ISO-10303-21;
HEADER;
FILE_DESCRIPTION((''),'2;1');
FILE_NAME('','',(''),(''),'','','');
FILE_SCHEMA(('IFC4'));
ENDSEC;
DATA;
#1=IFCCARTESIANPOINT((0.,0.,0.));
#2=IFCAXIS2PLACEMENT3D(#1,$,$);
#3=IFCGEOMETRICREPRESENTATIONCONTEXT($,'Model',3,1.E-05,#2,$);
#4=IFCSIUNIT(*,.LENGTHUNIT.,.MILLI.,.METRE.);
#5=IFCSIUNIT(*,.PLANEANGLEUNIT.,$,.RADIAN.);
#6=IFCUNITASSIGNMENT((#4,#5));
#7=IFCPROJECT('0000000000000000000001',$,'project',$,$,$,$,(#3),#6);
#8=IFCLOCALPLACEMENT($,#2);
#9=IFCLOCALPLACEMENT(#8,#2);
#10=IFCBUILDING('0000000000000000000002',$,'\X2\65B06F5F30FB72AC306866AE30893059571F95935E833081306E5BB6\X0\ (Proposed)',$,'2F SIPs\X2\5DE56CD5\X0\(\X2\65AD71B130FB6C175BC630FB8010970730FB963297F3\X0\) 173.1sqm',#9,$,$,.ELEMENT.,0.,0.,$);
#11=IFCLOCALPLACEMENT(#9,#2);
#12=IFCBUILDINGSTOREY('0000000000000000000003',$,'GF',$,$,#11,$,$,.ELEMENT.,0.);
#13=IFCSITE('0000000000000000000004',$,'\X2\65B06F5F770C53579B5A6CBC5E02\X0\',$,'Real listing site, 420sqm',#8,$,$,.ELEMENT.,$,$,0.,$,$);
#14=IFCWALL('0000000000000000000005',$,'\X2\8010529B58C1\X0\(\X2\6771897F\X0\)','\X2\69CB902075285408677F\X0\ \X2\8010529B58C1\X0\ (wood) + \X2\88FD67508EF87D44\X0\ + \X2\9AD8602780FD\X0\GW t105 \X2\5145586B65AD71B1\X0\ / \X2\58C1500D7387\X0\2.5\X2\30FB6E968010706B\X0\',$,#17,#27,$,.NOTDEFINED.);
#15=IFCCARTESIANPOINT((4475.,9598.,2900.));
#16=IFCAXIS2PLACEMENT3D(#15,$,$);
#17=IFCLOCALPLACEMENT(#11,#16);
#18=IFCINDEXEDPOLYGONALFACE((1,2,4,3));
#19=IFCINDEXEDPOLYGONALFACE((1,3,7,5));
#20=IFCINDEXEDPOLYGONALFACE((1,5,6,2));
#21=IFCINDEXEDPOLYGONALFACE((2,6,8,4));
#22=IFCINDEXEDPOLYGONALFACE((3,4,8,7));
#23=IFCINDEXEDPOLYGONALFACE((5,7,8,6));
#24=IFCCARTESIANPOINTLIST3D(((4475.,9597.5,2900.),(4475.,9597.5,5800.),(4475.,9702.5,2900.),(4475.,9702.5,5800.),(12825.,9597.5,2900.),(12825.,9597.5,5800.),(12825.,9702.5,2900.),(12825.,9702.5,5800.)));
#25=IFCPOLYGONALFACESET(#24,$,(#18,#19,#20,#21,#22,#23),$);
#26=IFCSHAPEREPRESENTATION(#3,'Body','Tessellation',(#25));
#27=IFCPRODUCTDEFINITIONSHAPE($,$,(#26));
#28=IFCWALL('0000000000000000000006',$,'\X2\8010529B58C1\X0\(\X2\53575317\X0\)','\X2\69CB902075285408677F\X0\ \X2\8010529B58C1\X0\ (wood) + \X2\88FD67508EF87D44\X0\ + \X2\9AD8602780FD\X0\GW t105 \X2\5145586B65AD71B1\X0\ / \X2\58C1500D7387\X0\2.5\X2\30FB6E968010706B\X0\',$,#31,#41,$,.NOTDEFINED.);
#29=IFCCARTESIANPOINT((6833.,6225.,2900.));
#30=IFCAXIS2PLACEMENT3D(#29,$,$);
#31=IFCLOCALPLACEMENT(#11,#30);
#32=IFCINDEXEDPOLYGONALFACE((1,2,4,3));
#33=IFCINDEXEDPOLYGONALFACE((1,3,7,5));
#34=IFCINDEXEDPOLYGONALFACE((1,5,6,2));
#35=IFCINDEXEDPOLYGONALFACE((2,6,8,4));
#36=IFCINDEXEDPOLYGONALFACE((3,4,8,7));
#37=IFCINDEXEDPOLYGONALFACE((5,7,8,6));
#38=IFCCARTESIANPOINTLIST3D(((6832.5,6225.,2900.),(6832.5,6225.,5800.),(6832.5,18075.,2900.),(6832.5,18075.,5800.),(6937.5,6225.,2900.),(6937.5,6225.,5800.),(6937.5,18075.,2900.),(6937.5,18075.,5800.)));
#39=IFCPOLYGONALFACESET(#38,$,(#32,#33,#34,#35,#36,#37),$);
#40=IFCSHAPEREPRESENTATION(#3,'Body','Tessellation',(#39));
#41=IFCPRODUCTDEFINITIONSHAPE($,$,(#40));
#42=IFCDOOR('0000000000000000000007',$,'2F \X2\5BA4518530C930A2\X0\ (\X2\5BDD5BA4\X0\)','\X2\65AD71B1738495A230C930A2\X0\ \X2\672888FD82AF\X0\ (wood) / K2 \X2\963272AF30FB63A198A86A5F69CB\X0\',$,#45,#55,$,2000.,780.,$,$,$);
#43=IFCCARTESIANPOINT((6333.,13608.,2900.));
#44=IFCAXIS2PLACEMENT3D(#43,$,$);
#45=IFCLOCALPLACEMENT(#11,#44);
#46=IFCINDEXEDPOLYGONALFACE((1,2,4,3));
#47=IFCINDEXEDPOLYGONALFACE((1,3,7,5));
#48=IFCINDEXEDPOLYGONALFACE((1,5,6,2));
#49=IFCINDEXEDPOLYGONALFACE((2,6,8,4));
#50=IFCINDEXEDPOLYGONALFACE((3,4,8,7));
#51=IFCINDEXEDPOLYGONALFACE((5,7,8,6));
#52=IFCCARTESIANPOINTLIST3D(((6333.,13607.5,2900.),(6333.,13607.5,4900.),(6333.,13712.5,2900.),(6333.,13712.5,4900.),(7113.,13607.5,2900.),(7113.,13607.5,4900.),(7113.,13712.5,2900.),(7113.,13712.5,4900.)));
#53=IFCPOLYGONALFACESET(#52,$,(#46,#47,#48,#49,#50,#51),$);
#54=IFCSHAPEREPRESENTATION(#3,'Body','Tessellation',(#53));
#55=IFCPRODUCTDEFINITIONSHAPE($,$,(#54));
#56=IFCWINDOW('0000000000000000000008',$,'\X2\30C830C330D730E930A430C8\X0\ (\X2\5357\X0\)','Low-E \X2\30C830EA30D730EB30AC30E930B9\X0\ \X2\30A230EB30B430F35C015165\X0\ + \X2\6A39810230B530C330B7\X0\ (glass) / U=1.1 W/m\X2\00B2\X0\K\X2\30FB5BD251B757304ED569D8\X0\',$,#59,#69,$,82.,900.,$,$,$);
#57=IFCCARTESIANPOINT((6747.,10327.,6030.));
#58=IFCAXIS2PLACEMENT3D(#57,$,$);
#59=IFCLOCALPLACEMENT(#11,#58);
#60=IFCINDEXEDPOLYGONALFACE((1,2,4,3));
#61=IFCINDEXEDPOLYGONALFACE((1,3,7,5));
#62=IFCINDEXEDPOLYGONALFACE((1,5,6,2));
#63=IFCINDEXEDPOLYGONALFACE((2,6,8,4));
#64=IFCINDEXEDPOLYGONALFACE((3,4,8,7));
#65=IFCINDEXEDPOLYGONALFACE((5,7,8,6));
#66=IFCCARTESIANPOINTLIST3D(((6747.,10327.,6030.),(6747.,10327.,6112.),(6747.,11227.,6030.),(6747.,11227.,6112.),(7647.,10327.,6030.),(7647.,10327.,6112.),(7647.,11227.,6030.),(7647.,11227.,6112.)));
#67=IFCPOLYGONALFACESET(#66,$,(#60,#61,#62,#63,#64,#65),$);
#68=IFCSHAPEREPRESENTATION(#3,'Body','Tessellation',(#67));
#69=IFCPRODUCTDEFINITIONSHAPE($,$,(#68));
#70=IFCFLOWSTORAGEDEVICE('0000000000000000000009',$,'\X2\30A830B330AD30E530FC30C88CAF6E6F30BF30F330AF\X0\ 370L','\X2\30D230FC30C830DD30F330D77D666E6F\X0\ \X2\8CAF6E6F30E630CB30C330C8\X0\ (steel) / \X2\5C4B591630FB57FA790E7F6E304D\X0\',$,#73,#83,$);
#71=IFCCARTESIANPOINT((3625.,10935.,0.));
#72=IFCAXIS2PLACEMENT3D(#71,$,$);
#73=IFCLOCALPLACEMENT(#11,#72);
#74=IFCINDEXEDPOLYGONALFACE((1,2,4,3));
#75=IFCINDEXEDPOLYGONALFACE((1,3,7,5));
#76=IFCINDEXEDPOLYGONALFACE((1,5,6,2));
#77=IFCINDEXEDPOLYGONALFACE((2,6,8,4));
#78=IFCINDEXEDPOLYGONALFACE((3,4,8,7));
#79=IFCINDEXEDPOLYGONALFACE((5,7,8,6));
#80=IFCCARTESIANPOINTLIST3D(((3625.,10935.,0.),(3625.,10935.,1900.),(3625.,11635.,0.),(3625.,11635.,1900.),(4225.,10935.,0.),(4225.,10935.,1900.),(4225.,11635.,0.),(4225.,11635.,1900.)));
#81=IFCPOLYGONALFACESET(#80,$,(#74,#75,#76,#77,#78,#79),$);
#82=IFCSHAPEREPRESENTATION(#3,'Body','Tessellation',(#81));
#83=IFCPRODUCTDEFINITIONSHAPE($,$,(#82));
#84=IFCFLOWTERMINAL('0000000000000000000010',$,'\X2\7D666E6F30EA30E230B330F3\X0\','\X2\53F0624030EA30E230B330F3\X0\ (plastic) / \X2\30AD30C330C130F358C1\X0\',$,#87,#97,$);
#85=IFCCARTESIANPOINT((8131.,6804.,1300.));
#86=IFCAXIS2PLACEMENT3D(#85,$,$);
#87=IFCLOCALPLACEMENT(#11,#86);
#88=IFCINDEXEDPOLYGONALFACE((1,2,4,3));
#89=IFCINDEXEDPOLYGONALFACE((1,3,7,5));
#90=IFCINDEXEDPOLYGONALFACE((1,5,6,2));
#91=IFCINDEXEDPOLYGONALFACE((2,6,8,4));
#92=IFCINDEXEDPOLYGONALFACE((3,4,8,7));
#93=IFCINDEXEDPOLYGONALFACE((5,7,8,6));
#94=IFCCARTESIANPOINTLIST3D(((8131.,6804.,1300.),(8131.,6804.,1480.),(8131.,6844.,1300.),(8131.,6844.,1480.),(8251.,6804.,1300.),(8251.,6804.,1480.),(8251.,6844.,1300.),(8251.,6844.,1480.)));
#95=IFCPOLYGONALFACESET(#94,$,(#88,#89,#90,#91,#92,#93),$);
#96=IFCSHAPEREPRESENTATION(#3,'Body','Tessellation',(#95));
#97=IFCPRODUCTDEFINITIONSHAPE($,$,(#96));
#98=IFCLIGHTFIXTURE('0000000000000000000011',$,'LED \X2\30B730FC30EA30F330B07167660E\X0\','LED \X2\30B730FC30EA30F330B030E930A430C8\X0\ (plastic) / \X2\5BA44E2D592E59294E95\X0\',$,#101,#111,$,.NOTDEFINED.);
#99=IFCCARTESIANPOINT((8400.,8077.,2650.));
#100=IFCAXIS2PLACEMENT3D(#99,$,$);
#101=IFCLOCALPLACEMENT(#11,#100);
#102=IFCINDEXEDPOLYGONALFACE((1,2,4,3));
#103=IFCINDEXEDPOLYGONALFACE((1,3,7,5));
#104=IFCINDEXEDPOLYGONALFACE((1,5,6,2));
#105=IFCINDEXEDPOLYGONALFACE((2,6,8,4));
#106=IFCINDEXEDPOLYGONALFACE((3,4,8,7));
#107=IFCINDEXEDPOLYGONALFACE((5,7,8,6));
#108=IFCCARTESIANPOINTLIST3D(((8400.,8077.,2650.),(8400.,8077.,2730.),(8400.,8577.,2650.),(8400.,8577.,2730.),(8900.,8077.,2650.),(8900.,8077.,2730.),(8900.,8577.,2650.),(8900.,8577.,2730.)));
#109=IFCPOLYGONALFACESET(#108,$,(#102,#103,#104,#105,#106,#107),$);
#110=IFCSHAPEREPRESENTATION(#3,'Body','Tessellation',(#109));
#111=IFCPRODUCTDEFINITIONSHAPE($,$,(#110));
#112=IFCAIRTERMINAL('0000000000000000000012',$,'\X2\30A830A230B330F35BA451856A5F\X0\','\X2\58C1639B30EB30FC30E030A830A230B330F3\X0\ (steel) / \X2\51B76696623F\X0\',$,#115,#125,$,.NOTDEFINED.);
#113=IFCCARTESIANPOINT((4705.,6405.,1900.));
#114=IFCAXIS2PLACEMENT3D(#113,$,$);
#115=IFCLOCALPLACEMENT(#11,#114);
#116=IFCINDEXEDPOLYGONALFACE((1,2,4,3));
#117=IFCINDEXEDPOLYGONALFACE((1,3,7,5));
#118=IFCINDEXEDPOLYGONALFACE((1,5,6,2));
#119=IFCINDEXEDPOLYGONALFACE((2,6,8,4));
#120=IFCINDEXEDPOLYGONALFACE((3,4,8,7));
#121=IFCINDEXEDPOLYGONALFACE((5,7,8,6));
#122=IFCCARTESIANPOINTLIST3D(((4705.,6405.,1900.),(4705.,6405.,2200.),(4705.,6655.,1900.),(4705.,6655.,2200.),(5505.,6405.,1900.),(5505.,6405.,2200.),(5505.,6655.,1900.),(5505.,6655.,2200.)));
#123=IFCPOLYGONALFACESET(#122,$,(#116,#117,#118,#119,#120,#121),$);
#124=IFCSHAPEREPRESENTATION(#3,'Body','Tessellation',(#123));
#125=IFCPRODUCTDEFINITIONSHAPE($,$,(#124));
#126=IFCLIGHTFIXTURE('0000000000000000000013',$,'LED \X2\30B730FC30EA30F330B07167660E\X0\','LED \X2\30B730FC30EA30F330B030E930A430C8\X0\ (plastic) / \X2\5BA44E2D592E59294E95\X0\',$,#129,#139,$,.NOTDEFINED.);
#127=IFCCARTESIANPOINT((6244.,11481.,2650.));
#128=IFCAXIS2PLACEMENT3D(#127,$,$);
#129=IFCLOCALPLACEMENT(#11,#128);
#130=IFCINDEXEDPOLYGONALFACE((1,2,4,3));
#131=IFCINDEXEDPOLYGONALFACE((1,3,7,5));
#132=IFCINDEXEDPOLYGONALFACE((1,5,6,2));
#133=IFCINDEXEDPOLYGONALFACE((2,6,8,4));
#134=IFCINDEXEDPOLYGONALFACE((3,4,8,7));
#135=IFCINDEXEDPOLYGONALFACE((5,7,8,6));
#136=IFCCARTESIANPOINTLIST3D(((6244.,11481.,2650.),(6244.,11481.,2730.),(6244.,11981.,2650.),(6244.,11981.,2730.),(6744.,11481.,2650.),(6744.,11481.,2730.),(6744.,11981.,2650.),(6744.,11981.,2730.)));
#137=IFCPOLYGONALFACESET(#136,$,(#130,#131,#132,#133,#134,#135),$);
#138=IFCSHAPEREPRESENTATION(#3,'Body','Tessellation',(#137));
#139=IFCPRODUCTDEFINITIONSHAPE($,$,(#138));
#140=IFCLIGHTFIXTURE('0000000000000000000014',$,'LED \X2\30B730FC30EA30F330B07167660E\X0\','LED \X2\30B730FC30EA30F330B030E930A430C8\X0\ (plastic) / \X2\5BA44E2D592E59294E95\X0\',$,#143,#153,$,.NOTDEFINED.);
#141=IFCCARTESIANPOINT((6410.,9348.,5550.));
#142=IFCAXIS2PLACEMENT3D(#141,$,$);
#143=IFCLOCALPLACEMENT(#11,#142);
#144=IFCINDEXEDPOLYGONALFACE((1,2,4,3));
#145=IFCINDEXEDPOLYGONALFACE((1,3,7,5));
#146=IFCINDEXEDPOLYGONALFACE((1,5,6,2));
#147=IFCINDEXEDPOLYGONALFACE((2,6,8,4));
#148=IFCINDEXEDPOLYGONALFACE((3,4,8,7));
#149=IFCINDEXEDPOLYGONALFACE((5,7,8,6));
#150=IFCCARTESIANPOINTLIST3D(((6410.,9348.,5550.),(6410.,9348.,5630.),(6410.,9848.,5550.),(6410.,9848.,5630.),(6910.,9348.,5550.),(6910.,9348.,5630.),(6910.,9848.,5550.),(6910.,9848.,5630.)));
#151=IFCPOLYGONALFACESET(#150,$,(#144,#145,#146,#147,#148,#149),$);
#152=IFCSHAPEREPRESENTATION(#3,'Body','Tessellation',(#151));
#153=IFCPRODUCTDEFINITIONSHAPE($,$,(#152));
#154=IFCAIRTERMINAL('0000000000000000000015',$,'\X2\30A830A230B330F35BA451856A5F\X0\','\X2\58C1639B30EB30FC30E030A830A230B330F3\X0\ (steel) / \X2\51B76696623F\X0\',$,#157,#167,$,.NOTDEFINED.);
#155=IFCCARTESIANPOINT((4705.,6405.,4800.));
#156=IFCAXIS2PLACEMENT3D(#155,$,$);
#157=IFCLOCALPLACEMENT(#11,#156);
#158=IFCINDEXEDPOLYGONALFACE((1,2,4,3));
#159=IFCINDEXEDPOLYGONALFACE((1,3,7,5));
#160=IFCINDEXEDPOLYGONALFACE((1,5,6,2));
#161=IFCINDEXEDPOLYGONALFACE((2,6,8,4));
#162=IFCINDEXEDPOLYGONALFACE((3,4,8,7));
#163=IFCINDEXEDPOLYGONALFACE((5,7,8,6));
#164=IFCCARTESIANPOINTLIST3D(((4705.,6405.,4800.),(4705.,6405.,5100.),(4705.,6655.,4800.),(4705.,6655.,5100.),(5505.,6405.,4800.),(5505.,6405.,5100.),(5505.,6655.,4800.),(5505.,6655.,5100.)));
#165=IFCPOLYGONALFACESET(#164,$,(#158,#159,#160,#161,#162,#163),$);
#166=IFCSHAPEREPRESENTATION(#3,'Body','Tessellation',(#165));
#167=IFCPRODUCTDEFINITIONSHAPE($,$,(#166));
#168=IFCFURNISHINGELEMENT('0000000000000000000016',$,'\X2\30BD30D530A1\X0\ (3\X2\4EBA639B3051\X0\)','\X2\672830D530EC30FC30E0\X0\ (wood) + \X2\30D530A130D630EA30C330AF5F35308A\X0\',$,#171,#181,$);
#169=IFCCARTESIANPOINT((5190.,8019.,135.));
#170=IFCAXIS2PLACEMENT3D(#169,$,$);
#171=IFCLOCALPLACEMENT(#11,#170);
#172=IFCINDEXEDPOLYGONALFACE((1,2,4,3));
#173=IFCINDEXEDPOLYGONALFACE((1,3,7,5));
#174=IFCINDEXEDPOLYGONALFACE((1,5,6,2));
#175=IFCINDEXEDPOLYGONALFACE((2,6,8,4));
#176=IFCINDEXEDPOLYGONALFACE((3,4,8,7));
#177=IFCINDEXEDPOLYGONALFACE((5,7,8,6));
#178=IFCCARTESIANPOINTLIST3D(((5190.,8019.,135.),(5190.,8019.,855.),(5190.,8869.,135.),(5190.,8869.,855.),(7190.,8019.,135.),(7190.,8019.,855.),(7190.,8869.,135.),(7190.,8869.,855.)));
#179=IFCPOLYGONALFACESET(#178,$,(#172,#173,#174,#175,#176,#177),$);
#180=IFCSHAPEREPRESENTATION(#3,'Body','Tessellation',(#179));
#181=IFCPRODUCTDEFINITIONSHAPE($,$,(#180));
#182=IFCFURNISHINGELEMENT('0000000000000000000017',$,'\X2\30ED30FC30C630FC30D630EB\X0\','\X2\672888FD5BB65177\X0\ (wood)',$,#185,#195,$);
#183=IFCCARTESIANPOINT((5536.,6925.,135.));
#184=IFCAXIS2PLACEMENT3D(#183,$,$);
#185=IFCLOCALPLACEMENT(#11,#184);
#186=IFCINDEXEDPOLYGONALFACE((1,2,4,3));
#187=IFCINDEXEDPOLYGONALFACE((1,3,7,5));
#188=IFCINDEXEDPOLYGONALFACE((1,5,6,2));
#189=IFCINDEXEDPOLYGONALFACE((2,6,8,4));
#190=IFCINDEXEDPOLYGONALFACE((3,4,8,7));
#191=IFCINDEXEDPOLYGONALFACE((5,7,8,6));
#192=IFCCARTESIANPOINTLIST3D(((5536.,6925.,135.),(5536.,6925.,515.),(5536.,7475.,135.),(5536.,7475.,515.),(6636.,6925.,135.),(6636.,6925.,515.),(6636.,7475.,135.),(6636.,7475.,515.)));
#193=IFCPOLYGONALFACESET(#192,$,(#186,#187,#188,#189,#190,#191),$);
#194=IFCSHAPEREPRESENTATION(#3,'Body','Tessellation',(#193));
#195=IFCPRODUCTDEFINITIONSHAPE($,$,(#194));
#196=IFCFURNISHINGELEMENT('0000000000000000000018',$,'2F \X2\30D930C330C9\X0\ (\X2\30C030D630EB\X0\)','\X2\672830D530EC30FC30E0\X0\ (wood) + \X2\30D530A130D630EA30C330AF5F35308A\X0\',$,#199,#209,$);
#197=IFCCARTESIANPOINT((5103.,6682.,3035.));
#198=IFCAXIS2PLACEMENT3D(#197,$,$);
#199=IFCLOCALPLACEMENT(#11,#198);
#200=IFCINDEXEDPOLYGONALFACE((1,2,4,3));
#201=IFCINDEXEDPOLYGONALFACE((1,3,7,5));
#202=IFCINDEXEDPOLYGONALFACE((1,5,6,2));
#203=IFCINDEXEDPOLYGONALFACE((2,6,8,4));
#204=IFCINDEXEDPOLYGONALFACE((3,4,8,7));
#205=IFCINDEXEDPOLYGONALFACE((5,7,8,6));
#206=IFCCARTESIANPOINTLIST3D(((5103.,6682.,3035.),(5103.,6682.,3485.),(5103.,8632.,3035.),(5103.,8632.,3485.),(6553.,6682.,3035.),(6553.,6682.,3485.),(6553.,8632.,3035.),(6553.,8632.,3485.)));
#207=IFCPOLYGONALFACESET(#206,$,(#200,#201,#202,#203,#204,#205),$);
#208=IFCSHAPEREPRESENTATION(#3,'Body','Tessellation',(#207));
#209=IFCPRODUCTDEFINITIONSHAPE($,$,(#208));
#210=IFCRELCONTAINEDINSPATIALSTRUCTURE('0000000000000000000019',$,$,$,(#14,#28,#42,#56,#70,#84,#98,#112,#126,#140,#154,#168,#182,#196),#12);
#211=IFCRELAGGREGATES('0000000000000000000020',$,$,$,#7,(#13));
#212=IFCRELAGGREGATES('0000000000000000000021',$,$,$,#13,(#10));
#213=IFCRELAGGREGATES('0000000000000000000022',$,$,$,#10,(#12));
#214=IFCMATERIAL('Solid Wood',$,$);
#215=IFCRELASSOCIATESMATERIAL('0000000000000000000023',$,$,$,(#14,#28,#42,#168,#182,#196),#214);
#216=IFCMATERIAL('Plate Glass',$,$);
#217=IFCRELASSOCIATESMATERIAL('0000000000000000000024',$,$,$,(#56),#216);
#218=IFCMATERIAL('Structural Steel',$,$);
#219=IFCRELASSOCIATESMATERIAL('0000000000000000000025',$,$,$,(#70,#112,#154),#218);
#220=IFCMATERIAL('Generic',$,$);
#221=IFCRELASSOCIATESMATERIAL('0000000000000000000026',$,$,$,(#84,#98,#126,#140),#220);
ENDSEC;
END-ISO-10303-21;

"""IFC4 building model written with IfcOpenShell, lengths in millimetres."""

from ifc_helpers import new_model, si_unit, frame, frame_2d, origin, place, context, project, spatial, rectangle, extrude, material, element, fill, save


model = new_model("IFC4")

# Units and contexts
model_context = context("Model", 3, precision=1e-05, world=origin())
ifc_project = project(units=[si_unit("LENGTHUNIT", "METRE", prefix="MILLI"), si_unit("PLANEANGLEUNIT", "RADIAN")], contexts=[model_context])

# Site, building, storey
site_placement = place(None, origin())
site = spatial("IfcSite", under=ifc_project, at=site_placement, Name="新潟県南魚沼市", ObjectType="Real listing site, 420sqm", CompositionType="ELEMENT", RefElevation=0.0)
building_placement = place(site_placement, origin())
building = spatial("IfcBuilding", under=site, at=building_placement, Name="新潟・犬と暮らす土間広めの家 (Proposed)", ObjectType="2F SIPs工法(断熱・気密・耐震・防音) 173.1sqm", CompositionType="ELEMENT", ElevationOfRefHeight=0.0, ElevationOfTerrain=0.0)
storey_placement = place(building_placement, origin())
storey = spatial("IfcBuildingStorey", under=building, at=storey_placement, Name="GF", CompositionType="ELEMENT", Elevation=0.0)

# Shared definitions
ifc_material_1 = material(Name="Solid Wood")

# Wall
wall_1_placement = place(storey_placement, frame((4475.0, 9598.0, 2900.0)))
element("IfcWall", 1, at=wall_1_placement, inside=storey, material=ifc_material_1, Name="耐力壁(東西)", Description="構造用合板 耐力壁 (wood) + 製材軸組 + 高性能GW t105 充填断熱 / 壁倍率2.5・準耐火", PredefinedType="NOTDEFINED", context=model_context, shape_type="SweptSolid", body=[
    extrude(rectangle(XDim=8350.0, YDim=105.0, at=frame_2d((4175.0, 52.0))), frame((4475.0, 9598.0, 2900.0)), (0.0, 0.0, 1.0), 2900.0),
])

# Wall, opening, door
wall_2_placement = place(storey_placement, frame((6833.0, 6225.0, 2900.0)))
wall_2 = element("IfcWall", 2, at=wall_2_placement, inside=storey, material=ifc_material_1, Name="耐力壁(南北)", Description="構造用合板 耐力壁 (wood) + 製材軸組 + 高性能GW t105 充填断熱 / 壁倍率2.5・準耐火", PredefinedType="NOTDEFINED", context=model_context, shape_type="SweptSolid", body=[
    extrude(rectangle(XDim=105.0, YDim=11850.0, at=frame_2d((52.0, 5925.0))), frame((6833.0, 6225.0, 2900.0)), (0.0, 0.0, 1.0), 2900.0),
])
opening_placement = place(storey_placement, frame((6333.0, 13608.0, 2900.0)))
opening = element("IfcOpeningElement", 3, at=opening_placement, cuts=wall_2, PredefinedType="NOTDEFINED", context=model_context, shape_type="SweptSolid", body=[
    extrude(rectangle(XDim=780.0, YDim=105.0, at=frame_2d((390.0, 52.0))), frame((6333.0, 13608.0, 2900.0)), (0.0, 0.0, 1.0), 2000.0),
])
door_placement = place(storey_placement, frame((6333.0, 13608.0, 2900.0)))
door = element("IfcDoor", 4, at=door_placement, inside=storey, material=ifc_material_1, Name="2F 室内ドア (寝室)", Description="断熱玄関ドア 木製芯 (wood) / K2 防犯・採風機構", OverallHeight=2000.0, OverallWidth=780.0, context=model_context, shape_type="SweptSolid", body=[
    extrude(rectangle(XDim=780.0, YDim=105.0, at=frame_2d((390.0, 52.0))), frame((6333.0, 13608.0, 2900.0)), (0.0, 0.0, 1.0), 2000.0),
])
fill(opening, door)

# Window
ifc_material_2 = material(Name="Plate Glass")
window_placement = place(storey_placement, frame((6747.0, 10327.0, 6030.0)))
element("IfcWindow", 5, at=window_placement, inside=storey, material=ifc_material_2, Name="トップライト (南)", Description="Low-E トリプルガラス アルゴン封入 + 樹脂サッシ (glass) / U=1.1 W/m²K・寒冷地仕様", OverallHeight=82.0, OverallWidth=900.0, context=model_context, shape_type="SweptSolid", body=[
    extrude(rectangle(XDim=900.0, YDim=900.0, at=frame_2d((450.0, 450.0))), frame((6747.0, 10327.0, 6030.0)), (0.0, 0.0, 1.0), 82.0),
])

# Flow storage device
ifc_material_3 = material(Name="Structural Steel")
flow_storage_device_placement = place(storey_placement, frame((3625.0, 10935.0, 0.0)))
element("IfcFlowStorageDevice", 6, at=flow_storage_device_placement, inside=storey, material=ifc_material_3, Name="エコキュート貯湯タンク 370L", Description="ヒートポンプ給湯 貯湯ユニット (steel) / 屋外・基礎置き", context=model_context, shape_type="SweptSolid", body=[
    extrude(rectangle(XDim=600.0, YDim=700.0, at=frame_2d((300.0, 350.0))), frame((3625.0, 10935.0, 0.0)), (0.0, 0.0, 1.0), 1900.0),
])

# Flow terminal
ifc_material_4 = material(Name="Generic")
flow_terminal_placement = place(storey_placement, frame((8131.0, 6804.0, 1300.0)))
element("IfcFlowTerminal", 7, at=flow_terminal_placement, inside=storey, material=ifc_material_4, Name="給湯リモコン", Description="台所リモコン (plastic) / キッチン壁", context=model_context, shape_type="SweptSolid", body=[
    extrude(rectangle(XDim=120.0, YDim=40.0, at=frame_2d((60.0, 20.0))), frame((8131.0, 6804.0, 1300.0)), (0.0, 0.0, 1.0), 180.0),
])

# Light fixture
light_fixture_1_placement = place(storey_placement, frame((8400.0, 8077.0, 2650.0)))
element("IfcLightFixture", 8, at=light_fixture_1_placement, inside=storey, material=ifc_material_4, Name="LED シーリング照明", Description="LED シーリングライト (plastic) / 室中央天井", PredefinedType="NOTDEFINED", context=model_context, shape_type="SweptSolid", body=[
    extrude(rectangle(XDim=500.0, YDim=500.0, at=frame_2d((250.0, 250.0))), frame((8400.0, 8077.0, 2650.0)), (0.0, 0.0, 1.0), 80.0),
])

# Air terminal
air_terminal_1_placement = place(storey_placement, frame((4705.0, 6405.0, 1900.0)))
element("IfcAirTerminal", 9, at=air_terminal_1_placement, inside=storey, material=ifc_material_3, Name="エアコン室内機", Description="壁掛ルームエアコン (steel) / 冷暖房", PredefinedType="NOTDEFINED", context=model_context, shape_type="SweptSolid", body=[
    extrude(rectangle(XDim=800.0, YDim=250.0, at=frame_2d((400.0, 125.0))), frame((4705.0, 6405.0, 1900.0)), (0.0, 0.0, 1.0), 300.0),
])

# Light fixtures
light_fixture_2_placement = place(storey_placement, frame((6244.0, 11481.0, 2650.0)))
element("IfcLightFixture", 10, at=light_fixture_2_placement, inside=storey, material=ifc_material_4, Name="LED シーリング照明", Description="LED シーリングライト (plastic) / 室中央天井", PredefinedType="NOTDEFINED", context=model_context, shape_type="SweptSolid", body=[
    extrude(rectangle(XDim=500.0, YDim=500.0, at=frame_2d((250.0, 250.0))), frame((6244.0, 11481.0, 2650.0)), (0.0, 0.0, 1.0), 80.0),
])
light_fixture_3_placement = place(storey_placement, frame((6410.0, 9348.0, 5550.0)))
element("IfcLightFixture", 11, at=light_fixture_3_placement, inside=storey, material=ifc_material_4, Name="LED シーリング照明", Description="LED シーリングライト (plastic) / 室中央天井", PredefinedType="NOTDEFINED", context=model_context, shape_type="SweptSolid", body=[
    extrude(rectangle(XDim=500.0, YDim=500.0, at=frame_2d((250.0, 250.0))), frame((6410.0, 9348.0, 5550.0)), (0.0, 0.0, 1.0), 80.0),
])

# Air terminal
air_terminal_2_placement = place(storey_placement, frame((4705.0, 6405.0, 4800.0)))
element("IfcAirTerminal", 12, at=air_terminal_2_placement, inside=storey, material=ifc_material_3, Name="エアコン室内機", Description="壁掛ルームエアコン (steel) / 冷暖房", PredefinedType="NOTDEFINED", context=model_context, shape_type="SweptSolid", body=[
    extrude(rectangle(XDim=800.0, YDim=250.0, at=frame_2d((400.0, 125.0))), frame((4705.0, 6405.0, 4800.0)), (0.0, 0.0, 1.0), 300.0),
])

# Furnishing elements
furnishing_1_placement = place(storey_placement, frame((5190.0, 8019.0, 135.0)))
element("IfcFurnishingElement", 13, at=furnishing_1_placement, inside=storey, material=ifc_material_1, Name="ソファ (3人掛け)", Description="木フレーム (wood) + ファブリック張り", context=model_context, shape_type="SweptSolid", body=[
    extrude(rectangle(XDim=2000.0, YDim=850.0, at=frame_2d((1000.0, 425.0))), frame((5190.0, 8019.0, 135.0)), (0.0, 0.0, 1.0), 720.0),
])
furnishing_2_placement = place(storey_placement, frame((5536.0, 6925.0, 135.0)))
element("IfcFurnishingElement", 14, at=furnishing_2_placement, inside=storey, material=ifc_material_1, Name="ローテーブル", Description="木製家具 (wood)", context=model_context, shape_type="SweptSolid", body=[
    extrude(rectangle(XDim=1100.0, YDim=550.0, at=frame_2d((550.0, 275.0))), frame((5536.0, 6925.0, 135.0)), (0.0, 0.0, 1.0), 380.0),
])
furnishing_3_placement = place(storey_placement, frame((5103.0, 6682.0, 3035.0)))
element("IfcFurnishingElement", 15, at=furnishing_3_placement, inside=storey, material=ifc_material_1, Name="2F ベッド (ダブル)", Description="木フレーム (wood) + ファブリック張り", context=model_context, shape_type="SweptSolid", body=[
    extrude(rectangle(XDim=1450.0, YDim=1950.0, at=frame_2d((725.0, 975.0))), frame((5103.0, 6682.0, 3035.0)), (0.0, 0.0, 1.0), 450.0),
])

save(model, "model.ifc")
